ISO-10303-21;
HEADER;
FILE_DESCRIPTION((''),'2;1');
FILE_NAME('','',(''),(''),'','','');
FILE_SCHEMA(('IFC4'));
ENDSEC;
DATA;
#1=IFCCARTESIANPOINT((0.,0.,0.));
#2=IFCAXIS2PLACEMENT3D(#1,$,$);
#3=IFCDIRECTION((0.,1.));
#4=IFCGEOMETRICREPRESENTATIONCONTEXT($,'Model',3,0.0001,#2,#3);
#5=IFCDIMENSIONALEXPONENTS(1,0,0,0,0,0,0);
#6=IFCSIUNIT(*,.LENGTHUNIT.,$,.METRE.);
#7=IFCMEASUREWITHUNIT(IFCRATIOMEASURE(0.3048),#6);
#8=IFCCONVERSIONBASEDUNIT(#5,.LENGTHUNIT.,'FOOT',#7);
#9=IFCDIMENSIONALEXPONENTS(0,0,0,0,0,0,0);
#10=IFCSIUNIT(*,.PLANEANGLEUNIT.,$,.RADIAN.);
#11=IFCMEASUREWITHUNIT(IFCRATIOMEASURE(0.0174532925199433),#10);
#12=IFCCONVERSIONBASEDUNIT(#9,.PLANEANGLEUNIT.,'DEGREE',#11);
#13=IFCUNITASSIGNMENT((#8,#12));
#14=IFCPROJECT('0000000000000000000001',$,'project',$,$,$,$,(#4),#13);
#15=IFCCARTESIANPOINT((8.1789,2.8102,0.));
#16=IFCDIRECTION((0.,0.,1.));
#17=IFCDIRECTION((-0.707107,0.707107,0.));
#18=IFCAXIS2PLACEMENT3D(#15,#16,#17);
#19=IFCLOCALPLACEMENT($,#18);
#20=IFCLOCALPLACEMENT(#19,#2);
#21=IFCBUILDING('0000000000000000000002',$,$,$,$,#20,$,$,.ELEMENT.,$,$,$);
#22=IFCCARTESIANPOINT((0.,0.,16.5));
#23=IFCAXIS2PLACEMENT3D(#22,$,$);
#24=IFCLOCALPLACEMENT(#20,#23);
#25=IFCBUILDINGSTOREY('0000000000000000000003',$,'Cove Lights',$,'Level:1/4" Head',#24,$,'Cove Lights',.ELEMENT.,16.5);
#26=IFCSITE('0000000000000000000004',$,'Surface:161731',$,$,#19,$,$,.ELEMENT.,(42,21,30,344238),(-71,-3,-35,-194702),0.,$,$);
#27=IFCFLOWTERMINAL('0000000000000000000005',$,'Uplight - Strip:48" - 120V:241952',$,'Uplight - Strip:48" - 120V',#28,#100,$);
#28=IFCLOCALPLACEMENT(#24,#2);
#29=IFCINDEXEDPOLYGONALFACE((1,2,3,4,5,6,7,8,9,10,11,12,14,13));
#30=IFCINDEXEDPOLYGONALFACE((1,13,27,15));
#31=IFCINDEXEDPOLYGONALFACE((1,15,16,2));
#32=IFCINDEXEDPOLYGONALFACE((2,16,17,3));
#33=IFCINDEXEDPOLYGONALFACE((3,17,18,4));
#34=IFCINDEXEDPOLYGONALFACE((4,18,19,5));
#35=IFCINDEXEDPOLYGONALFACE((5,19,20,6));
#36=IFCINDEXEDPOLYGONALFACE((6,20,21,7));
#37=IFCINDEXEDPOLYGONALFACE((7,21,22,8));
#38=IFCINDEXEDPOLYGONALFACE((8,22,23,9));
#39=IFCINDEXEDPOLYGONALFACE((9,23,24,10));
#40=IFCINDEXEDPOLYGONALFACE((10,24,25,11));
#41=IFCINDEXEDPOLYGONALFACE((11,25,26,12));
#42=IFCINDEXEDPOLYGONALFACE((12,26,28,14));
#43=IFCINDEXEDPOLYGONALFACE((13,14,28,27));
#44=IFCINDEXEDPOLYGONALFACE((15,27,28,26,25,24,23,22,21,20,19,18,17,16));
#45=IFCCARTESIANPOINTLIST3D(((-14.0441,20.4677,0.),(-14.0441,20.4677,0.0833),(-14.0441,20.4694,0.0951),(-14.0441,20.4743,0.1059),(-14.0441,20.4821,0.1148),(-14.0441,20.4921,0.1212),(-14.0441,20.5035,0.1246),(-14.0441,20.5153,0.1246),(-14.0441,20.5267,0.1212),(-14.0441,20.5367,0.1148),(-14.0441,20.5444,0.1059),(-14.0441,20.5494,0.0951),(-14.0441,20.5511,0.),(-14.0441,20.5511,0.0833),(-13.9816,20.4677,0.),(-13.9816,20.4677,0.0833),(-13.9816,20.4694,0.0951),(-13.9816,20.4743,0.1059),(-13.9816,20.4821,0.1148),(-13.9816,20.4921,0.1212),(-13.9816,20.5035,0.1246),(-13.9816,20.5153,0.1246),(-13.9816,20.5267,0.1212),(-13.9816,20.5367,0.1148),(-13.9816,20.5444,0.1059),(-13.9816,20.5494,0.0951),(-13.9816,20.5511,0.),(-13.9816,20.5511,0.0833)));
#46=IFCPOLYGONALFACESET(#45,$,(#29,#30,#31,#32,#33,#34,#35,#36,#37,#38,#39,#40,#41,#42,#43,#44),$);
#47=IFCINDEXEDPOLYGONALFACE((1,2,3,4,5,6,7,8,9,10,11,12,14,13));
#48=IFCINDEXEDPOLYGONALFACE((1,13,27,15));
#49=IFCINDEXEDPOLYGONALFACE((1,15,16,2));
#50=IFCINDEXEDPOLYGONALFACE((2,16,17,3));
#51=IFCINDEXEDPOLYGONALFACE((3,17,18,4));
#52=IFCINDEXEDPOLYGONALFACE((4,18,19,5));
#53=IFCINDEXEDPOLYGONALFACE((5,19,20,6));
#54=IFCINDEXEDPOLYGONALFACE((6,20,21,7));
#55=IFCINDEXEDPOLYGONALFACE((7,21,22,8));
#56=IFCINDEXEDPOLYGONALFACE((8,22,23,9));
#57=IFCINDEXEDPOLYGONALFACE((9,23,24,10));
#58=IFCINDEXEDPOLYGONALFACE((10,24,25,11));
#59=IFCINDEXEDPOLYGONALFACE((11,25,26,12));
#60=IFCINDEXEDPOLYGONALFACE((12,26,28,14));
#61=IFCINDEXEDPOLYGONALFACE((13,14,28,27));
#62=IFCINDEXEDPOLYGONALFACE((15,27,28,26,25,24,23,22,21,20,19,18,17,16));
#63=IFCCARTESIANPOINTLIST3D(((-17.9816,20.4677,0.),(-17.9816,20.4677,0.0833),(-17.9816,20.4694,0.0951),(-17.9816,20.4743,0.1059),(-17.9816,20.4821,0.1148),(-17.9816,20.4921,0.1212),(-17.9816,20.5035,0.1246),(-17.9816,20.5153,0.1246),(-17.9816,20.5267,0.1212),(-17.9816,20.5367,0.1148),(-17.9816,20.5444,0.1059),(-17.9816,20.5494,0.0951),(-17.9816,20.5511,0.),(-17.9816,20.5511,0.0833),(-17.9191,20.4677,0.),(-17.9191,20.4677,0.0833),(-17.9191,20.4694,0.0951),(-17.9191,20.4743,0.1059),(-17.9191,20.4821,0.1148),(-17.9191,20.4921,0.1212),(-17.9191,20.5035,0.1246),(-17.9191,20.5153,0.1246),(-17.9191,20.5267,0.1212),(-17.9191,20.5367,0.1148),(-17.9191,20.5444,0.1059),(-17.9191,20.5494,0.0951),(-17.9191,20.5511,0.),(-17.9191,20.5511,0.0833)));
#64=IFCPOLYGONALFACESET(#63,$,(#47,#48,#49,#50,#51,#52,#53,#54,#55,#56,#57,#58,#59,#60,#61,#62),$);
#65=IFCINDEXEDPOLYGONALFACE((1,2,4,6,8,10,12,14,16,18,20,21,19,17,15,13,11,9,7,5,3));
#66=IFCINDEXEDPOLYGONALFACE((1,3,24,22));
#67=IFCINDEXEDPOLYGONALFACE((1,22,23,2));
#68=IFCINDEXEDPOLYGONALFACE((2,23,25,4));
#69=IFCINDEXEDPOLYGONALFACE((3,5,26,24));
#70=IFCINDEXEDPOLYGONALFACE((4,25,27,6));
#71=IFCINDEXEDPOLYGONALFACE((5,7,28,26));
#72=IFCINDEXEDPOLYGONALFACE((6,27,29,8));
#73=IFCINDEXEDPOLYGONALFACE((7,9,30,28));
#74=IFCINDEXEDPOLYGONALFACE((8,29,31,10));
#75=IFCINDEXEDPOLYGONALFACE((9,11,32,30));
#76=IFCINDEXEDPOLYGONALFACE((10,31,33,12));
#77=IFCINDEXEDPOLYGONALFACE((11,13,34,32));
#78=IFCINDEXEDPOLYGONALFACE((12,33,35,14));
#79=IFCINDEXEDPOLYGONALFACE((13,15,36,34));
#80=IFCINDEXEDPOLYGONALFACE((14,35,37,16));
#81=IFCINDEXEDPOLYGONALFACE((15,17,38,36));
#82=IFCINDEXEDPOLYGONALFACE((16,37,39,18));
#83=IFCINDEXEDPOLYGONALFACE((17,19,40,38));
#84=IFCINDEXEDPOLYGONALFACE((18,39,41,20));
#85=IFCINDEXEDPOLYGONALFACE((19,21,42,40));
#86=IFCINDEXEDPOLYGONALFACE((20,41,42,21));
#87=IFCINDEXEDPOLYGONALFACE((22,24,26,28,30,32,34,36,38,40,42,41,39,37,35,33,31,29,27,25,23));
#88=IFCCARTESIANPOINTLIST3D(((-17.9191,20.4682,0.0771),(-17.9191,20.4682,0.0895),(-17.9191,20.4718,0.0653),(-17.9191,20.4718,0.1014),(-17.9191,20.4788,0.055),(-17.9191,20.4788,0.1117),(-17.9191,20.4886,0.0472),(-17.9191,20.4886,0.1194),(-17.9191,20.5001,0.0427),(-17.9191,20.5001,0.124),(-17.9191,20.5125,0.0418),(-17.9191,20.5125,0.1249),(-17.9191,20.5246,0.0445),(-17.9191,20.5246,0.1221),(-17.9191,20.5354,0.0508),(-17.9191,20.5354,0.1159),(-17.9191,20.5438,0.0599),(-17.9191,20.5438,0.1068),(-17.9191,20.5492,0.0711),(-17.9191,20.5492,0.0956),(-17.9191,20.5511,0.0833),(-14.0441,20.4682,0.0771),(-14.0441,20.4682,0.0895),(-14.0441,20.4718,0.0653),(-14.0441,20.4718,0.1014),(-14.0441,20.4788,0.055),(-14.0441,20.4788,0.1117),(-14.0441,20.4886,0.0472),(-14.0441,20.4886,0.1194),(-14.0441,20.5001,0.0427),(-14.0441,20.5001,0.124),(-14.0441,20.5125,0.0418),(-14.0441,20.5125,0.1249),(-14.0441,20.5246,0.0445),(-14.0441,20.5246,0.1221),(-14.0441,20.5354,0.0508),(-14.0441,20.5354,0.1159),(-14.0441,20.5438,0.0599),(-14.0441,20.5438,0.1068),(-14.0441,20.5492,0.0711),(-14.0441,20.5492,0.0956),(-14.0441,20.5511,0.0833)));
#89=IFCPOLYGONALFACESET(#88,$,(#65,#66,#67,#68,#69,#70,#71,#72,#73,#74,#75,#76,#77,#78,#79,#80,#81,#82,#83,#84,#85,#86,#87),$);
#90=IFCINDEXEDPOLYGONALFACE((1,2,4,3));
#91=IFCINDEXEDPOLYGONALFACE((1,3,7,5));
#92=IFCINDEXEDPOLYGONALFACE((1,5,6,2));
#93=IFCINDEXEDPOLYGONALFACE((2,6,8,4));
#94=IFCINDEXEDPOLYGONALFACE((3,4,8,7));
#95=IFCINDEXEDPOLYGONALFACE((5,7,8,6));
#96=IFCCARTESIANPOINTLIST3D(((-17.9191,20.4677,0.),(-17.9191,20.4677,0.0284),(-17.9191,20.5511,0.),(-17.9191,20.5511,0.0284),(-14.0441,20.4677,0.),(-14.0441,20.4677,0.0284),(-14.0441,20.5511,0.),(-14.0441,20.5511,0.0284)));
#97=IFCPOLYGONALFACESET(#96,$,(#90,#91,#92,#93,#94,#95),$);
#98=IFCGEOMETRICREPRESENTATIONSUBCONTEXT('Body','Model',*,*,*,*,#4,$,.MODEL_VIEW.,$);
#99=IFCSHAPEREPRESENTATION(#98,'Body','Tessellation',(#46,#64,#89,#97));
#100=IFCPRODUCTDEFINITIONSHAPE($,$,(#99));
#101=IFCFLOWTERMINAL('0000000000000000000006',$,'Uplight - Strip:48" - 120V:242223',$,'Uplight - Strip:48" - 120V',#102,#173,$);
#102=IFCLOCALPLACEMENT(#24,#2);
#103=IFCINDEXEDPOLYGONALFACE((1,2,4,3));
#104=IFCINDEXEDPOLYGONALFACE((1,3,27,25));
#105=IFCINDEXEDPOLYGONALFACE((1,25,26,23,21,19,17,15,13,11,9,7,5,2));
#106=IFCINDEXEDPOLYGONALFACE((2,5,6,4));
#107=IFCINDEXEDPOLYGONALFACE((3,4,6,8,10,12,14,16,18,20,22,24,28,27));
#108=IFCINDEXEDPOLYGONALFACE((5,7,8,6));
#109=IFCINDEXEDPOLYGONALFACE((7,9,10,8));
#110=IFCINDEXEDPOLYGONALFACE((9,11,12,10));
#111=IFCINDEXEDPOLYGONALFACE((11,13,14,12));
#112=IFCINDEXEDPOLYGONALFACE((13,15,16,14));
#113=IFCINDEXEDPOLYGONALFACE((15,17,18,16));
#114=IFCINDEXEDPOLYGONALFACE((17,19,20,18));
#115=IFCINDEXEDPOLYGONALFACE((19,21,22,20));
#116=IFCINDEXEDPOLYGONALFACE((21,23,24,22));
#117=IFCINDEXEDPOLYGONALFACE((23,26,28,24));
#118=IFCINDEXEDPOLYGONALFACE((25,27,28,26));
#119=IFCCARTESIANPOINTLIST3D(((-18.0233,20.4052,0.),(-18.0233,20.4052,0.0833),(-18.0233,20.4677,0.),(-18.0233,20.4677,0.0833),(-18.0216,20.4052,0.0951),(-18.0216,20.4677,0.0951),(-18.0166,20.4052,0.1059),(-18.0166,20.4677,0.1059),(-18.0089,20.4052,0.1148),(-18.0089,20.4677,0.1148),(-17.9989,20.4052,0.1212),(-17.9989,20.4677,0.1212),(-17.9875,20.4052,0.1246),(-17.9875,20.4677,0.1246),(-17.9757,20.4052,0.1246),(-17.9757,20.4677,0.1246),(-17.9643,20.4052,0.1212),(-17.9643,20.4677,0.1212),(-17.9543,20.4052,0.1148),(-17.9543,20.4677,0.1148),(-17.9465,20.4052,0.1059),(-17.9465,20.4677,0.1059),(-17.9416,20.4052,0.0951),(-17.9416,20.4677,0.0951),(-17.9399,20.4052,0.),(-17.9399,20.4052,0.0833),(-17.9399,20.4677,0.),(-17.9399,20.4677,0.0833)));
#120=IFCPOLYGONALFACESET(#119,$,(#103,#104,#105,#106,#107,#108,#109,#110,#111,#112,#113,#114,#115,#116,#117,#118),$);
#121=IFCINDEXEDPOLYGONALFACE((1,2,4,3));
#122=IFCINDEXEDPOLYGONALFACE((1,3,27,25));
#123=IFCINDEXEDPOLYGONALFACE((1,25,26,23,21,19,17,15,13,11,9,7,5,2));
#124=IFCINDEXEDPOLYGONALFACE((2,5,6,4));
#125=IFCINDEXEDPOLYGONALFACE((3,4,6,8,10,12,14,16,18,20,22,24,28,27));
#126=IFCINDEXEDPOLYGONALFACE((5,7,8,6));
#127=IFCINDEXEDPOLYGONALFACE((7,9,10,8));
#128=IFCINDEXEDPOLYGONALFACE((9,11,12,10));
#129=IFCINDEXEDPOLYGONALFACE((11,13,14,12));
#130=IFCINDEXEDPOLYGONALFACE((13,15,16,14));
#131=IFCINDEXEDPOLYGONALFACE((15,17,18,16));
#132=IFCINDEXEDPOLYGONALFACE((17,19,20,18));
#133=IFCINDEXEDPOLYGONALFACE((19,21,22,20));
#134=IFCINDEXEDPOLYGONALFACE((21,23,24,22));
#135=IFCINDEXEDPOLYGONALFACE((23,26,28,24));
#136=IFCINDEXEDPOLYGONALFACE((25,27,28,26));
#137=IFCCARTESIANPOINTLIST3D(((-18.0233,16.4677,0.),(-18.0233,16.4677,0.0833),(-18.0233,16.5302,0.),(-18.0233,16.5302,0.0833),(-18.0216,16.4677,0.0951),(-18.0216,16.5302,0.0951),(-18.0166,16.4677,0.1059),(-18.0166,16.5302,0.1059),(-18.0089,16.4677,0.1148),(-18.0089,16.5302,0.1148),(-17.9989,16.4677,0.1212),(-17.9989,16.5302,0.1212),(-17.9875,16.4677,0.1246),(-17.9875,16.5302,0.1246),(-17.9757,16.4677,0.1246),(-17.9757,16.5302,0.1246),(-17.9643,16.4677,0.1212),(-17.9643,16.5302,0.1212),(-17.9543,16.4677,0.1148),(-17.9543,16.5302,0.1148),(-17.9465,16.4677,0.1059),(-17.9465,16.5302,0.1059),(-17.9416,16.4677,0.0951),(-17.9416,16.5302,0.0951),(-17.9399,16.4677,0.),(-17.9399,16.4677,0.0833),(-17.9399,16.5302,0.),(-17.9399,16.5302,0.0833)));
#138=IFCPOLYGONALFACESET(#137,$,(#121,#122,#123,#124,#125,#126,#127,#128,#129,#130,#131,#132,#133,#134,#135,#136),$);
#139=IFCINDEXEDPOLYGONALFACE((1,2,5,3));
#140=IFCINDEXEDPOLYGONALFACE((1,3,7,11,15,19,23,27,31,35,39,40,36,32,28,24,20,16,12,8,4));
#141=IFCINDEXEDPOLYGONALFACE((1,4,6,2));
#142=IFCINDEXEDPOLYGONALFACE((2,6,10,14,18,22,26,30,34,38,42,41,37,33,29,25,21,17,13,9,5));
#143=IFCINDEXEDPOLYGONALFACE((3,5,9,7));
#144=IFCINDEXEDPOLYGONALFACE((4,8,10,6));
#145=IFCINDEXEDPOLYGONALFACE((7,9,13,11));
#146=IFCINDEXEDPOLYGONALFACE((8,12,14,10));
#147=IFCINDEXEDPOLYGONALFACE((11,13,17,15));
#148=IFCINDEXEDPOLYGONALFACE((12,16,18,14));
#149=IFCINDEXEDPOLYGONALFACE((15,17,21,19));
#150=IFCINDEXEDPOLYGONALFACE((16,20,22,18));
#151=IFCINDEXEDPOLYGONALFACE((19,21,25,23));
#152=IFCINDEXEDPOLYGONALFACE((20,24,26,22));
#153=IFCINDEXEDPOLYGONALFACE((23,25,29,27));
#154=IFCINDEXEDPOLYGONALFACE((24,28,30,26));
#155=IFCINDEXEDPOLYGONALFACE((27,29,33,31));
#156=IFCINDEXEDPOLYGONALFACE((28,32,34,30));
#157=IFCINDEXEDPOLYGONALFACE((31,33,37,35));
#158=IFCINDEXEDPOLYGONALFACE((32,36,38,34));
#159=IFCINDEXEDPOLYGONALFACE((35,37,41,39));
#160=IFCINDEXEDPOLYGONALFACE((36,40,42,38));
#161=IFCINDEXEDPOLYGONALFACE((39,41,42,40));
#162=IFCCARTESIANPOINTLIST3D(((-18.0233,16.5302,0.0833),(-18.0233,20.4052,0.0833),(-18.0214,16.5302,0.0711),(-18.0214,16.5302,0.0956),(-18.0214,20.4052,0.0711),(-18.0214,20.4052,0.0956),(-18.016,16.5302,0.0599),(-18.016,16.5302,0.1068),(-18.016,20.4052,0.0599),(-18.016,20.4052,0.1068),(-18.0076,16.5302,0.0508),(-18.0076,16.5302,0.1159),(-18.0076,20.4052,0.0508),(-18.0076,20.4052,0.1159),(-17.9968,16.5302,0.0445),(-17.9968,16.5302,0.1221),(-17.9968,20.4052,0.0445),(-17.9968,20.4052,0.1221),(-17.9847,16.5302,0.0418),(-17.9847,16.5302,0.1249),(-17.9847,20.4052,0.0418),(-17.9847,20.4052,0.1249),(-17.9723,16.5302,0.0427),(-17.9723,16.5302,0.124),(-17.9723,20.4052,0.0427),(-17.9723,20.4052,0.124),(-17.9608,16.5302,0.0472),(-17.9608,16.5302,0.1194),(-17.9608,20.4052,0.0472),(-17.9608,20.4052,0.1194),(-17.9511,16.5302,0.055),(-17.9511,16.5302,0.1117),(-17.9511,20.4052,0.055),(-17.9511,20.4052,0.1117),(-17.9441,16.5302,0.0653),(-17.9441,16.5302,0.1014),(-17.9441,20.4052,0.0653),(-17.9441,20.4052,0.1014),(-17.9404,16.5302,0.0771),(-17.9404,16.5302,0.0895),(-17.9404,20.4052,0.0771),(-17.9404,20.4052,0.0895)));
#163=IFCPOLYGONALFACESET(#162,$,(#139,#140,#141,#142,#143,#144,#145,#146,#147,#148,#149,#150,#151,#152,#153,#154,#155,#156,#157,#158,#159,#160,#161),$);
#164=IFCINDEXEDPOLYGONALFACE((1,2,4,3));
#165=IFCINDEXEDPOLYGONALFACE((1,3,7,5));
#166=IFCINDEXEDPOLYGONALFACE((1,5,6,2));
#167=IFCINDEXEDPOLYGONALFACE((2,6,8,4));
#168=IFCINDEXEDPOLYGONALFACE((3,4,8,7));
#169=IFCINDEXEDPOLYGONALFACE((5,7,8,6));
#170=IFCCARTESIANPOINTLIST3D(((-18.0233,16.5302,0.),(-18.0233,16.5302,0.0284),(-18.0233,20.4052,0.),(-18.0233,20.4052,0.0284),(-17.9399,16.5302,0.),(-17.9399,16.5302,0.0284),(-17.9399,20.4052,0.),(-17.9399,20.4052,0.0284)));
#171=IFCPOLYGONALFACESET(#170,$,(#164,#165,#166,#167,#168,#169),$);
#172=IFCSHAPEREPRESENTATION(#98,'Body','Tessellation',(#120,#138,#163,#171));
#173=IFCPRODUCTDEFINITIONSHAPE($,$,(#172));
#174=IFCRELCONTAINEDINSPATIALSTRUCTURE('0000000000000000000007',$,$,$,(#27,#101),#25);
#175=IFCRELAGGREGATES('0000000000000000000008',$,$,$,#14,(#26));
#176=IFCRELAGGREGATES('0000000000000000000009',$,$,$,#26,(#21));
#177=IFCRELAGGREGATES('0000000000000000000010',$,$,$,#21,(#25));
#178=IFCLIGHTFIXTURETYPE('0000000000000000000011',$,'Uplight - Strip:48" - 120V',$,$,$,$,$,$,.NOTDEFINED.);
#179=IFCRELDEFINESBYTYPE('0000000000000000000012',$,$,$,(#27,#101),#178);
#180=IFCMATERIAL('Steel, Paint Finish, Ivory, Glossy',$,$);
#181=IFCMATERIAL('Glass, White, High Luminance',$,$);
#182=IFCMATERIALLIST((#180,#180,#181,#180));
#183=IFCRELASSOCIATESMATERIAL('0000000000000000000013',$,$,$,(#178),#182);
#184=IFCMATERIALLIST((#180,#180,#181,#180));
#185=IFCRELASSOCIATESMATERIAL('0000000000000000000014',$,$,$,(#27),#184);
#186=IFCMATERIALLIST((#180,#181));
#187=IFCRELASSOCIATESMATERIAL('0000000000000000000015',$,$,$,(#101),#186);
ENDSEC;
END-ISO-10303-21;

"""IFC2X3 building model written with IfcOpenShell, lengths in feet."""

from ifc_helpers import new_model, entity, si_unit, converted_unit, direction, frame, frame_2d, origin, origin_2d_with_axis, place, context, subcontext, project, spatial, polyline, circle_curve, parameter, trimmed, segment, composite_curve, rectangle, circle, outline, extrude, source, transform, mapped, material, material_list, type_object, type_shapes, element, save


model = new_model("IFC2X3")

# Units and contexts
model_context = context("Model", 3, precision=0.0001, world=origin(), true_north=direction((0.0, 1.0)))
body_context = subcontext(model_context, "Body", "Model", "MODEL_VIEW")
ifc_project = project(units=[converted_unit("LENGTHUNIT", "FOOT", entity("IfcRatioMeasure", 0.3048), si_unit("LENGTHUNIT", "METRE"), dimensions=[1, 0, 0, 0, 0, 0, 0]), converted_unit("PLANEANGLEUNIT", "DEGREE", entity("IfcRatioMeasure", 0.0174532925199433), si_unit("PLANEANGLEUNIT", "RADIAN"), dimensions=[0, 0, 0, 0, 0, 0, 0])], contexts=[model_context])

# Site, building, storey
site_placement = place(None, frame((8.1789, 2.8102, 0.0), z_axis=(0.0, 0.0, 1.0), x_axis=(-0.707107, 0.707107, 0.0)))
site = spatial("IfcSite", under=ifc_project, at=site_placement, Name="Surface:161731", CompositionType="ELEMENT", RefLatitude=(42, 21, 30, 344238), RefLongitude=(-71, -3, -35, -194702), RefElevation=0.0)
building_placement = place(site_placement, origin())
building = spatial("IfcBuilding", under=site, at=building_placement, CompositionType="ELEMENT")
storey_placement = place(building_placement, frame((0.0, 0.0, 16.5)))
storey = spatial("IfcBuildingStorey", under=building, at=storey_placement, Name="Cove Lights", ObjectType="Level:1/4\" Head", LongName="Cove Lights", CompositionType="ELEMENT", Elevation=16.5)

# Flow terminals
ifc_material_1 = material(Name="Steel, Paint Finish, Ivory, Glossy")
ifc_material_2 = material(Name="Glass, White, High Luminance")
ifc_material_list_1 = material_list([ifc_material_1, ifc_material_1, ifc_material_2, ifc_material_1])
ifc_material_list_2 = material_list([ifc_material_1, ifc_material_1, ifc_material_2, ifc_material_1])
light_fixture_type_1 = type_object("IfcLightFixtureType", Name="Uplight - Strip:48\" - 120V", PredefinedType="NOTDEFINED", material=ifc_material_list_2)
shared_shape_1 = source(origin(), body_context, "Body", "SweptSolid", [
    extrude(outline(composite_curve([segment(polyline([(-0.0417, -0.0417), (0.0417, -0.0417)]), True, "CONTINUOUS"), segment(trimmed(circle_curve(frame_2d((0.0417, 0.0), x_axis=(0.0, -1.0)), 0.0417), [parameter(0.0)], [parameter(180.0)], True, "PARAMETER"), True, "CONTINUOUS"), segment(polyline([(0.0417, 0.0417), (-0.0417, 0.0417)]), True, "CONTINUOUS"), segment(polyline([(-0.0417, 0.0417), (-0.0417, -0.0417)]), True, "CONTINUOUS")], self_intersect=False)), frame((1.9375, 0.0, 0.0417), z_axis=(1.0, 0.0, 0.0), x_axis=(0.0, 0.0, 1.0)), (0.0, 0.0, 1.0), 0.0625),
    extrude(outline(composite_curve([segment(polyline([(-0.0417, -0.0417), (0.0417, -0.0417)]), True, "CONTINUOUS"), segment(polyline([(0.0417, -0.0417), (0.0417, 0.0417)]), True, "CONTINUOUS"), segment(trimmed(circle_curve(frame_2d((0.0, 0.0417), x_axis=(0.0, 1.0)), 0.0417), [parameter(270.0)], [parameter(90.0)], True, "PARAMETER"), True, "CONTINUOUS"), segment(polyline([(-0.0417, 0.0417), (-0.0417, -0.0417)]), True, "CONTINUOUS")], self_intersect=False)), frame((-2.0, 0.0, 0.0417), z_axis=(1.0, 0.0, 0.0), x_axis=(0.0, 1.0, 0.0)), (0.0, 0.0, 1.0), 0.0625),
    extrude(circle(Radius=0.0417, at=frame_2d((0.0, 0.0), x_axis=(1.0, 0.0))), frame((-1.9375, 0.0, 0.0833), z_axis=(1.0, 0.0, 0.0), x_axis=(0.0, 1.0, 0.0)), (0.0, 0.0, 1.0), 3.875),
    extrude(rectangle(XDim=3.875, YDim=0.0833, at=origin_2d_with_axis()), frame((0.0, 0.0, 0.0), z_axis=(0.0, 0.0, 1.0), x_axis=(-1.0, 0.0, 0.0)), (0.0, 0.0, 1.0), 0.0284),
])
type_shapes(light_fixture_type_1, [shared_shape_1])
flow_terminal_1_placement = place(storey_placement, frame((-15.9816, 20.5094, 0.0)))
element("IfcFlowTerminal", 1, at=flow_terminal_1_placement, inside=storey, type_object=light_fixture_type_1, material=ifc_material_list_1, Name="Uplight - Strip:48\" - 120V:241952", ObjectType="Uplight - Strip:48\" - 120V", context=body_context, shape_type="MappedRepresentation", body=[
    mapped(shared_shape_1, transform((0.0, 0.0, 0.0), scale=1.0)),
])
ifc_material_list_3 = material_list([ifc_material_1, ifc_material_2])
flow_terminal_2_placement = place(storey_placement, frame((-17.9816, 18.4677, 0.0), z_axis=(0.0, 0.0, 1.0), x_axis=(0.0, 1.0, 0.0)))
element("IfcFlowTerminal", 2, at=flow_terminal_2_placement, inside=storey, type_object=light_fixture_type_1, material=ifc_material_list_3, Name="Uplight - Strip:48\" - 120V:242223", ObjectType="Uplight - Strip:48\" - 120V", context=body_context, shape_type="MappedRepresentation", body=[
    mapped(shared_shape_1, transform((0.0, 0.0, 0.0), scale=1.0)),
])

save(model, "model.ifc")
